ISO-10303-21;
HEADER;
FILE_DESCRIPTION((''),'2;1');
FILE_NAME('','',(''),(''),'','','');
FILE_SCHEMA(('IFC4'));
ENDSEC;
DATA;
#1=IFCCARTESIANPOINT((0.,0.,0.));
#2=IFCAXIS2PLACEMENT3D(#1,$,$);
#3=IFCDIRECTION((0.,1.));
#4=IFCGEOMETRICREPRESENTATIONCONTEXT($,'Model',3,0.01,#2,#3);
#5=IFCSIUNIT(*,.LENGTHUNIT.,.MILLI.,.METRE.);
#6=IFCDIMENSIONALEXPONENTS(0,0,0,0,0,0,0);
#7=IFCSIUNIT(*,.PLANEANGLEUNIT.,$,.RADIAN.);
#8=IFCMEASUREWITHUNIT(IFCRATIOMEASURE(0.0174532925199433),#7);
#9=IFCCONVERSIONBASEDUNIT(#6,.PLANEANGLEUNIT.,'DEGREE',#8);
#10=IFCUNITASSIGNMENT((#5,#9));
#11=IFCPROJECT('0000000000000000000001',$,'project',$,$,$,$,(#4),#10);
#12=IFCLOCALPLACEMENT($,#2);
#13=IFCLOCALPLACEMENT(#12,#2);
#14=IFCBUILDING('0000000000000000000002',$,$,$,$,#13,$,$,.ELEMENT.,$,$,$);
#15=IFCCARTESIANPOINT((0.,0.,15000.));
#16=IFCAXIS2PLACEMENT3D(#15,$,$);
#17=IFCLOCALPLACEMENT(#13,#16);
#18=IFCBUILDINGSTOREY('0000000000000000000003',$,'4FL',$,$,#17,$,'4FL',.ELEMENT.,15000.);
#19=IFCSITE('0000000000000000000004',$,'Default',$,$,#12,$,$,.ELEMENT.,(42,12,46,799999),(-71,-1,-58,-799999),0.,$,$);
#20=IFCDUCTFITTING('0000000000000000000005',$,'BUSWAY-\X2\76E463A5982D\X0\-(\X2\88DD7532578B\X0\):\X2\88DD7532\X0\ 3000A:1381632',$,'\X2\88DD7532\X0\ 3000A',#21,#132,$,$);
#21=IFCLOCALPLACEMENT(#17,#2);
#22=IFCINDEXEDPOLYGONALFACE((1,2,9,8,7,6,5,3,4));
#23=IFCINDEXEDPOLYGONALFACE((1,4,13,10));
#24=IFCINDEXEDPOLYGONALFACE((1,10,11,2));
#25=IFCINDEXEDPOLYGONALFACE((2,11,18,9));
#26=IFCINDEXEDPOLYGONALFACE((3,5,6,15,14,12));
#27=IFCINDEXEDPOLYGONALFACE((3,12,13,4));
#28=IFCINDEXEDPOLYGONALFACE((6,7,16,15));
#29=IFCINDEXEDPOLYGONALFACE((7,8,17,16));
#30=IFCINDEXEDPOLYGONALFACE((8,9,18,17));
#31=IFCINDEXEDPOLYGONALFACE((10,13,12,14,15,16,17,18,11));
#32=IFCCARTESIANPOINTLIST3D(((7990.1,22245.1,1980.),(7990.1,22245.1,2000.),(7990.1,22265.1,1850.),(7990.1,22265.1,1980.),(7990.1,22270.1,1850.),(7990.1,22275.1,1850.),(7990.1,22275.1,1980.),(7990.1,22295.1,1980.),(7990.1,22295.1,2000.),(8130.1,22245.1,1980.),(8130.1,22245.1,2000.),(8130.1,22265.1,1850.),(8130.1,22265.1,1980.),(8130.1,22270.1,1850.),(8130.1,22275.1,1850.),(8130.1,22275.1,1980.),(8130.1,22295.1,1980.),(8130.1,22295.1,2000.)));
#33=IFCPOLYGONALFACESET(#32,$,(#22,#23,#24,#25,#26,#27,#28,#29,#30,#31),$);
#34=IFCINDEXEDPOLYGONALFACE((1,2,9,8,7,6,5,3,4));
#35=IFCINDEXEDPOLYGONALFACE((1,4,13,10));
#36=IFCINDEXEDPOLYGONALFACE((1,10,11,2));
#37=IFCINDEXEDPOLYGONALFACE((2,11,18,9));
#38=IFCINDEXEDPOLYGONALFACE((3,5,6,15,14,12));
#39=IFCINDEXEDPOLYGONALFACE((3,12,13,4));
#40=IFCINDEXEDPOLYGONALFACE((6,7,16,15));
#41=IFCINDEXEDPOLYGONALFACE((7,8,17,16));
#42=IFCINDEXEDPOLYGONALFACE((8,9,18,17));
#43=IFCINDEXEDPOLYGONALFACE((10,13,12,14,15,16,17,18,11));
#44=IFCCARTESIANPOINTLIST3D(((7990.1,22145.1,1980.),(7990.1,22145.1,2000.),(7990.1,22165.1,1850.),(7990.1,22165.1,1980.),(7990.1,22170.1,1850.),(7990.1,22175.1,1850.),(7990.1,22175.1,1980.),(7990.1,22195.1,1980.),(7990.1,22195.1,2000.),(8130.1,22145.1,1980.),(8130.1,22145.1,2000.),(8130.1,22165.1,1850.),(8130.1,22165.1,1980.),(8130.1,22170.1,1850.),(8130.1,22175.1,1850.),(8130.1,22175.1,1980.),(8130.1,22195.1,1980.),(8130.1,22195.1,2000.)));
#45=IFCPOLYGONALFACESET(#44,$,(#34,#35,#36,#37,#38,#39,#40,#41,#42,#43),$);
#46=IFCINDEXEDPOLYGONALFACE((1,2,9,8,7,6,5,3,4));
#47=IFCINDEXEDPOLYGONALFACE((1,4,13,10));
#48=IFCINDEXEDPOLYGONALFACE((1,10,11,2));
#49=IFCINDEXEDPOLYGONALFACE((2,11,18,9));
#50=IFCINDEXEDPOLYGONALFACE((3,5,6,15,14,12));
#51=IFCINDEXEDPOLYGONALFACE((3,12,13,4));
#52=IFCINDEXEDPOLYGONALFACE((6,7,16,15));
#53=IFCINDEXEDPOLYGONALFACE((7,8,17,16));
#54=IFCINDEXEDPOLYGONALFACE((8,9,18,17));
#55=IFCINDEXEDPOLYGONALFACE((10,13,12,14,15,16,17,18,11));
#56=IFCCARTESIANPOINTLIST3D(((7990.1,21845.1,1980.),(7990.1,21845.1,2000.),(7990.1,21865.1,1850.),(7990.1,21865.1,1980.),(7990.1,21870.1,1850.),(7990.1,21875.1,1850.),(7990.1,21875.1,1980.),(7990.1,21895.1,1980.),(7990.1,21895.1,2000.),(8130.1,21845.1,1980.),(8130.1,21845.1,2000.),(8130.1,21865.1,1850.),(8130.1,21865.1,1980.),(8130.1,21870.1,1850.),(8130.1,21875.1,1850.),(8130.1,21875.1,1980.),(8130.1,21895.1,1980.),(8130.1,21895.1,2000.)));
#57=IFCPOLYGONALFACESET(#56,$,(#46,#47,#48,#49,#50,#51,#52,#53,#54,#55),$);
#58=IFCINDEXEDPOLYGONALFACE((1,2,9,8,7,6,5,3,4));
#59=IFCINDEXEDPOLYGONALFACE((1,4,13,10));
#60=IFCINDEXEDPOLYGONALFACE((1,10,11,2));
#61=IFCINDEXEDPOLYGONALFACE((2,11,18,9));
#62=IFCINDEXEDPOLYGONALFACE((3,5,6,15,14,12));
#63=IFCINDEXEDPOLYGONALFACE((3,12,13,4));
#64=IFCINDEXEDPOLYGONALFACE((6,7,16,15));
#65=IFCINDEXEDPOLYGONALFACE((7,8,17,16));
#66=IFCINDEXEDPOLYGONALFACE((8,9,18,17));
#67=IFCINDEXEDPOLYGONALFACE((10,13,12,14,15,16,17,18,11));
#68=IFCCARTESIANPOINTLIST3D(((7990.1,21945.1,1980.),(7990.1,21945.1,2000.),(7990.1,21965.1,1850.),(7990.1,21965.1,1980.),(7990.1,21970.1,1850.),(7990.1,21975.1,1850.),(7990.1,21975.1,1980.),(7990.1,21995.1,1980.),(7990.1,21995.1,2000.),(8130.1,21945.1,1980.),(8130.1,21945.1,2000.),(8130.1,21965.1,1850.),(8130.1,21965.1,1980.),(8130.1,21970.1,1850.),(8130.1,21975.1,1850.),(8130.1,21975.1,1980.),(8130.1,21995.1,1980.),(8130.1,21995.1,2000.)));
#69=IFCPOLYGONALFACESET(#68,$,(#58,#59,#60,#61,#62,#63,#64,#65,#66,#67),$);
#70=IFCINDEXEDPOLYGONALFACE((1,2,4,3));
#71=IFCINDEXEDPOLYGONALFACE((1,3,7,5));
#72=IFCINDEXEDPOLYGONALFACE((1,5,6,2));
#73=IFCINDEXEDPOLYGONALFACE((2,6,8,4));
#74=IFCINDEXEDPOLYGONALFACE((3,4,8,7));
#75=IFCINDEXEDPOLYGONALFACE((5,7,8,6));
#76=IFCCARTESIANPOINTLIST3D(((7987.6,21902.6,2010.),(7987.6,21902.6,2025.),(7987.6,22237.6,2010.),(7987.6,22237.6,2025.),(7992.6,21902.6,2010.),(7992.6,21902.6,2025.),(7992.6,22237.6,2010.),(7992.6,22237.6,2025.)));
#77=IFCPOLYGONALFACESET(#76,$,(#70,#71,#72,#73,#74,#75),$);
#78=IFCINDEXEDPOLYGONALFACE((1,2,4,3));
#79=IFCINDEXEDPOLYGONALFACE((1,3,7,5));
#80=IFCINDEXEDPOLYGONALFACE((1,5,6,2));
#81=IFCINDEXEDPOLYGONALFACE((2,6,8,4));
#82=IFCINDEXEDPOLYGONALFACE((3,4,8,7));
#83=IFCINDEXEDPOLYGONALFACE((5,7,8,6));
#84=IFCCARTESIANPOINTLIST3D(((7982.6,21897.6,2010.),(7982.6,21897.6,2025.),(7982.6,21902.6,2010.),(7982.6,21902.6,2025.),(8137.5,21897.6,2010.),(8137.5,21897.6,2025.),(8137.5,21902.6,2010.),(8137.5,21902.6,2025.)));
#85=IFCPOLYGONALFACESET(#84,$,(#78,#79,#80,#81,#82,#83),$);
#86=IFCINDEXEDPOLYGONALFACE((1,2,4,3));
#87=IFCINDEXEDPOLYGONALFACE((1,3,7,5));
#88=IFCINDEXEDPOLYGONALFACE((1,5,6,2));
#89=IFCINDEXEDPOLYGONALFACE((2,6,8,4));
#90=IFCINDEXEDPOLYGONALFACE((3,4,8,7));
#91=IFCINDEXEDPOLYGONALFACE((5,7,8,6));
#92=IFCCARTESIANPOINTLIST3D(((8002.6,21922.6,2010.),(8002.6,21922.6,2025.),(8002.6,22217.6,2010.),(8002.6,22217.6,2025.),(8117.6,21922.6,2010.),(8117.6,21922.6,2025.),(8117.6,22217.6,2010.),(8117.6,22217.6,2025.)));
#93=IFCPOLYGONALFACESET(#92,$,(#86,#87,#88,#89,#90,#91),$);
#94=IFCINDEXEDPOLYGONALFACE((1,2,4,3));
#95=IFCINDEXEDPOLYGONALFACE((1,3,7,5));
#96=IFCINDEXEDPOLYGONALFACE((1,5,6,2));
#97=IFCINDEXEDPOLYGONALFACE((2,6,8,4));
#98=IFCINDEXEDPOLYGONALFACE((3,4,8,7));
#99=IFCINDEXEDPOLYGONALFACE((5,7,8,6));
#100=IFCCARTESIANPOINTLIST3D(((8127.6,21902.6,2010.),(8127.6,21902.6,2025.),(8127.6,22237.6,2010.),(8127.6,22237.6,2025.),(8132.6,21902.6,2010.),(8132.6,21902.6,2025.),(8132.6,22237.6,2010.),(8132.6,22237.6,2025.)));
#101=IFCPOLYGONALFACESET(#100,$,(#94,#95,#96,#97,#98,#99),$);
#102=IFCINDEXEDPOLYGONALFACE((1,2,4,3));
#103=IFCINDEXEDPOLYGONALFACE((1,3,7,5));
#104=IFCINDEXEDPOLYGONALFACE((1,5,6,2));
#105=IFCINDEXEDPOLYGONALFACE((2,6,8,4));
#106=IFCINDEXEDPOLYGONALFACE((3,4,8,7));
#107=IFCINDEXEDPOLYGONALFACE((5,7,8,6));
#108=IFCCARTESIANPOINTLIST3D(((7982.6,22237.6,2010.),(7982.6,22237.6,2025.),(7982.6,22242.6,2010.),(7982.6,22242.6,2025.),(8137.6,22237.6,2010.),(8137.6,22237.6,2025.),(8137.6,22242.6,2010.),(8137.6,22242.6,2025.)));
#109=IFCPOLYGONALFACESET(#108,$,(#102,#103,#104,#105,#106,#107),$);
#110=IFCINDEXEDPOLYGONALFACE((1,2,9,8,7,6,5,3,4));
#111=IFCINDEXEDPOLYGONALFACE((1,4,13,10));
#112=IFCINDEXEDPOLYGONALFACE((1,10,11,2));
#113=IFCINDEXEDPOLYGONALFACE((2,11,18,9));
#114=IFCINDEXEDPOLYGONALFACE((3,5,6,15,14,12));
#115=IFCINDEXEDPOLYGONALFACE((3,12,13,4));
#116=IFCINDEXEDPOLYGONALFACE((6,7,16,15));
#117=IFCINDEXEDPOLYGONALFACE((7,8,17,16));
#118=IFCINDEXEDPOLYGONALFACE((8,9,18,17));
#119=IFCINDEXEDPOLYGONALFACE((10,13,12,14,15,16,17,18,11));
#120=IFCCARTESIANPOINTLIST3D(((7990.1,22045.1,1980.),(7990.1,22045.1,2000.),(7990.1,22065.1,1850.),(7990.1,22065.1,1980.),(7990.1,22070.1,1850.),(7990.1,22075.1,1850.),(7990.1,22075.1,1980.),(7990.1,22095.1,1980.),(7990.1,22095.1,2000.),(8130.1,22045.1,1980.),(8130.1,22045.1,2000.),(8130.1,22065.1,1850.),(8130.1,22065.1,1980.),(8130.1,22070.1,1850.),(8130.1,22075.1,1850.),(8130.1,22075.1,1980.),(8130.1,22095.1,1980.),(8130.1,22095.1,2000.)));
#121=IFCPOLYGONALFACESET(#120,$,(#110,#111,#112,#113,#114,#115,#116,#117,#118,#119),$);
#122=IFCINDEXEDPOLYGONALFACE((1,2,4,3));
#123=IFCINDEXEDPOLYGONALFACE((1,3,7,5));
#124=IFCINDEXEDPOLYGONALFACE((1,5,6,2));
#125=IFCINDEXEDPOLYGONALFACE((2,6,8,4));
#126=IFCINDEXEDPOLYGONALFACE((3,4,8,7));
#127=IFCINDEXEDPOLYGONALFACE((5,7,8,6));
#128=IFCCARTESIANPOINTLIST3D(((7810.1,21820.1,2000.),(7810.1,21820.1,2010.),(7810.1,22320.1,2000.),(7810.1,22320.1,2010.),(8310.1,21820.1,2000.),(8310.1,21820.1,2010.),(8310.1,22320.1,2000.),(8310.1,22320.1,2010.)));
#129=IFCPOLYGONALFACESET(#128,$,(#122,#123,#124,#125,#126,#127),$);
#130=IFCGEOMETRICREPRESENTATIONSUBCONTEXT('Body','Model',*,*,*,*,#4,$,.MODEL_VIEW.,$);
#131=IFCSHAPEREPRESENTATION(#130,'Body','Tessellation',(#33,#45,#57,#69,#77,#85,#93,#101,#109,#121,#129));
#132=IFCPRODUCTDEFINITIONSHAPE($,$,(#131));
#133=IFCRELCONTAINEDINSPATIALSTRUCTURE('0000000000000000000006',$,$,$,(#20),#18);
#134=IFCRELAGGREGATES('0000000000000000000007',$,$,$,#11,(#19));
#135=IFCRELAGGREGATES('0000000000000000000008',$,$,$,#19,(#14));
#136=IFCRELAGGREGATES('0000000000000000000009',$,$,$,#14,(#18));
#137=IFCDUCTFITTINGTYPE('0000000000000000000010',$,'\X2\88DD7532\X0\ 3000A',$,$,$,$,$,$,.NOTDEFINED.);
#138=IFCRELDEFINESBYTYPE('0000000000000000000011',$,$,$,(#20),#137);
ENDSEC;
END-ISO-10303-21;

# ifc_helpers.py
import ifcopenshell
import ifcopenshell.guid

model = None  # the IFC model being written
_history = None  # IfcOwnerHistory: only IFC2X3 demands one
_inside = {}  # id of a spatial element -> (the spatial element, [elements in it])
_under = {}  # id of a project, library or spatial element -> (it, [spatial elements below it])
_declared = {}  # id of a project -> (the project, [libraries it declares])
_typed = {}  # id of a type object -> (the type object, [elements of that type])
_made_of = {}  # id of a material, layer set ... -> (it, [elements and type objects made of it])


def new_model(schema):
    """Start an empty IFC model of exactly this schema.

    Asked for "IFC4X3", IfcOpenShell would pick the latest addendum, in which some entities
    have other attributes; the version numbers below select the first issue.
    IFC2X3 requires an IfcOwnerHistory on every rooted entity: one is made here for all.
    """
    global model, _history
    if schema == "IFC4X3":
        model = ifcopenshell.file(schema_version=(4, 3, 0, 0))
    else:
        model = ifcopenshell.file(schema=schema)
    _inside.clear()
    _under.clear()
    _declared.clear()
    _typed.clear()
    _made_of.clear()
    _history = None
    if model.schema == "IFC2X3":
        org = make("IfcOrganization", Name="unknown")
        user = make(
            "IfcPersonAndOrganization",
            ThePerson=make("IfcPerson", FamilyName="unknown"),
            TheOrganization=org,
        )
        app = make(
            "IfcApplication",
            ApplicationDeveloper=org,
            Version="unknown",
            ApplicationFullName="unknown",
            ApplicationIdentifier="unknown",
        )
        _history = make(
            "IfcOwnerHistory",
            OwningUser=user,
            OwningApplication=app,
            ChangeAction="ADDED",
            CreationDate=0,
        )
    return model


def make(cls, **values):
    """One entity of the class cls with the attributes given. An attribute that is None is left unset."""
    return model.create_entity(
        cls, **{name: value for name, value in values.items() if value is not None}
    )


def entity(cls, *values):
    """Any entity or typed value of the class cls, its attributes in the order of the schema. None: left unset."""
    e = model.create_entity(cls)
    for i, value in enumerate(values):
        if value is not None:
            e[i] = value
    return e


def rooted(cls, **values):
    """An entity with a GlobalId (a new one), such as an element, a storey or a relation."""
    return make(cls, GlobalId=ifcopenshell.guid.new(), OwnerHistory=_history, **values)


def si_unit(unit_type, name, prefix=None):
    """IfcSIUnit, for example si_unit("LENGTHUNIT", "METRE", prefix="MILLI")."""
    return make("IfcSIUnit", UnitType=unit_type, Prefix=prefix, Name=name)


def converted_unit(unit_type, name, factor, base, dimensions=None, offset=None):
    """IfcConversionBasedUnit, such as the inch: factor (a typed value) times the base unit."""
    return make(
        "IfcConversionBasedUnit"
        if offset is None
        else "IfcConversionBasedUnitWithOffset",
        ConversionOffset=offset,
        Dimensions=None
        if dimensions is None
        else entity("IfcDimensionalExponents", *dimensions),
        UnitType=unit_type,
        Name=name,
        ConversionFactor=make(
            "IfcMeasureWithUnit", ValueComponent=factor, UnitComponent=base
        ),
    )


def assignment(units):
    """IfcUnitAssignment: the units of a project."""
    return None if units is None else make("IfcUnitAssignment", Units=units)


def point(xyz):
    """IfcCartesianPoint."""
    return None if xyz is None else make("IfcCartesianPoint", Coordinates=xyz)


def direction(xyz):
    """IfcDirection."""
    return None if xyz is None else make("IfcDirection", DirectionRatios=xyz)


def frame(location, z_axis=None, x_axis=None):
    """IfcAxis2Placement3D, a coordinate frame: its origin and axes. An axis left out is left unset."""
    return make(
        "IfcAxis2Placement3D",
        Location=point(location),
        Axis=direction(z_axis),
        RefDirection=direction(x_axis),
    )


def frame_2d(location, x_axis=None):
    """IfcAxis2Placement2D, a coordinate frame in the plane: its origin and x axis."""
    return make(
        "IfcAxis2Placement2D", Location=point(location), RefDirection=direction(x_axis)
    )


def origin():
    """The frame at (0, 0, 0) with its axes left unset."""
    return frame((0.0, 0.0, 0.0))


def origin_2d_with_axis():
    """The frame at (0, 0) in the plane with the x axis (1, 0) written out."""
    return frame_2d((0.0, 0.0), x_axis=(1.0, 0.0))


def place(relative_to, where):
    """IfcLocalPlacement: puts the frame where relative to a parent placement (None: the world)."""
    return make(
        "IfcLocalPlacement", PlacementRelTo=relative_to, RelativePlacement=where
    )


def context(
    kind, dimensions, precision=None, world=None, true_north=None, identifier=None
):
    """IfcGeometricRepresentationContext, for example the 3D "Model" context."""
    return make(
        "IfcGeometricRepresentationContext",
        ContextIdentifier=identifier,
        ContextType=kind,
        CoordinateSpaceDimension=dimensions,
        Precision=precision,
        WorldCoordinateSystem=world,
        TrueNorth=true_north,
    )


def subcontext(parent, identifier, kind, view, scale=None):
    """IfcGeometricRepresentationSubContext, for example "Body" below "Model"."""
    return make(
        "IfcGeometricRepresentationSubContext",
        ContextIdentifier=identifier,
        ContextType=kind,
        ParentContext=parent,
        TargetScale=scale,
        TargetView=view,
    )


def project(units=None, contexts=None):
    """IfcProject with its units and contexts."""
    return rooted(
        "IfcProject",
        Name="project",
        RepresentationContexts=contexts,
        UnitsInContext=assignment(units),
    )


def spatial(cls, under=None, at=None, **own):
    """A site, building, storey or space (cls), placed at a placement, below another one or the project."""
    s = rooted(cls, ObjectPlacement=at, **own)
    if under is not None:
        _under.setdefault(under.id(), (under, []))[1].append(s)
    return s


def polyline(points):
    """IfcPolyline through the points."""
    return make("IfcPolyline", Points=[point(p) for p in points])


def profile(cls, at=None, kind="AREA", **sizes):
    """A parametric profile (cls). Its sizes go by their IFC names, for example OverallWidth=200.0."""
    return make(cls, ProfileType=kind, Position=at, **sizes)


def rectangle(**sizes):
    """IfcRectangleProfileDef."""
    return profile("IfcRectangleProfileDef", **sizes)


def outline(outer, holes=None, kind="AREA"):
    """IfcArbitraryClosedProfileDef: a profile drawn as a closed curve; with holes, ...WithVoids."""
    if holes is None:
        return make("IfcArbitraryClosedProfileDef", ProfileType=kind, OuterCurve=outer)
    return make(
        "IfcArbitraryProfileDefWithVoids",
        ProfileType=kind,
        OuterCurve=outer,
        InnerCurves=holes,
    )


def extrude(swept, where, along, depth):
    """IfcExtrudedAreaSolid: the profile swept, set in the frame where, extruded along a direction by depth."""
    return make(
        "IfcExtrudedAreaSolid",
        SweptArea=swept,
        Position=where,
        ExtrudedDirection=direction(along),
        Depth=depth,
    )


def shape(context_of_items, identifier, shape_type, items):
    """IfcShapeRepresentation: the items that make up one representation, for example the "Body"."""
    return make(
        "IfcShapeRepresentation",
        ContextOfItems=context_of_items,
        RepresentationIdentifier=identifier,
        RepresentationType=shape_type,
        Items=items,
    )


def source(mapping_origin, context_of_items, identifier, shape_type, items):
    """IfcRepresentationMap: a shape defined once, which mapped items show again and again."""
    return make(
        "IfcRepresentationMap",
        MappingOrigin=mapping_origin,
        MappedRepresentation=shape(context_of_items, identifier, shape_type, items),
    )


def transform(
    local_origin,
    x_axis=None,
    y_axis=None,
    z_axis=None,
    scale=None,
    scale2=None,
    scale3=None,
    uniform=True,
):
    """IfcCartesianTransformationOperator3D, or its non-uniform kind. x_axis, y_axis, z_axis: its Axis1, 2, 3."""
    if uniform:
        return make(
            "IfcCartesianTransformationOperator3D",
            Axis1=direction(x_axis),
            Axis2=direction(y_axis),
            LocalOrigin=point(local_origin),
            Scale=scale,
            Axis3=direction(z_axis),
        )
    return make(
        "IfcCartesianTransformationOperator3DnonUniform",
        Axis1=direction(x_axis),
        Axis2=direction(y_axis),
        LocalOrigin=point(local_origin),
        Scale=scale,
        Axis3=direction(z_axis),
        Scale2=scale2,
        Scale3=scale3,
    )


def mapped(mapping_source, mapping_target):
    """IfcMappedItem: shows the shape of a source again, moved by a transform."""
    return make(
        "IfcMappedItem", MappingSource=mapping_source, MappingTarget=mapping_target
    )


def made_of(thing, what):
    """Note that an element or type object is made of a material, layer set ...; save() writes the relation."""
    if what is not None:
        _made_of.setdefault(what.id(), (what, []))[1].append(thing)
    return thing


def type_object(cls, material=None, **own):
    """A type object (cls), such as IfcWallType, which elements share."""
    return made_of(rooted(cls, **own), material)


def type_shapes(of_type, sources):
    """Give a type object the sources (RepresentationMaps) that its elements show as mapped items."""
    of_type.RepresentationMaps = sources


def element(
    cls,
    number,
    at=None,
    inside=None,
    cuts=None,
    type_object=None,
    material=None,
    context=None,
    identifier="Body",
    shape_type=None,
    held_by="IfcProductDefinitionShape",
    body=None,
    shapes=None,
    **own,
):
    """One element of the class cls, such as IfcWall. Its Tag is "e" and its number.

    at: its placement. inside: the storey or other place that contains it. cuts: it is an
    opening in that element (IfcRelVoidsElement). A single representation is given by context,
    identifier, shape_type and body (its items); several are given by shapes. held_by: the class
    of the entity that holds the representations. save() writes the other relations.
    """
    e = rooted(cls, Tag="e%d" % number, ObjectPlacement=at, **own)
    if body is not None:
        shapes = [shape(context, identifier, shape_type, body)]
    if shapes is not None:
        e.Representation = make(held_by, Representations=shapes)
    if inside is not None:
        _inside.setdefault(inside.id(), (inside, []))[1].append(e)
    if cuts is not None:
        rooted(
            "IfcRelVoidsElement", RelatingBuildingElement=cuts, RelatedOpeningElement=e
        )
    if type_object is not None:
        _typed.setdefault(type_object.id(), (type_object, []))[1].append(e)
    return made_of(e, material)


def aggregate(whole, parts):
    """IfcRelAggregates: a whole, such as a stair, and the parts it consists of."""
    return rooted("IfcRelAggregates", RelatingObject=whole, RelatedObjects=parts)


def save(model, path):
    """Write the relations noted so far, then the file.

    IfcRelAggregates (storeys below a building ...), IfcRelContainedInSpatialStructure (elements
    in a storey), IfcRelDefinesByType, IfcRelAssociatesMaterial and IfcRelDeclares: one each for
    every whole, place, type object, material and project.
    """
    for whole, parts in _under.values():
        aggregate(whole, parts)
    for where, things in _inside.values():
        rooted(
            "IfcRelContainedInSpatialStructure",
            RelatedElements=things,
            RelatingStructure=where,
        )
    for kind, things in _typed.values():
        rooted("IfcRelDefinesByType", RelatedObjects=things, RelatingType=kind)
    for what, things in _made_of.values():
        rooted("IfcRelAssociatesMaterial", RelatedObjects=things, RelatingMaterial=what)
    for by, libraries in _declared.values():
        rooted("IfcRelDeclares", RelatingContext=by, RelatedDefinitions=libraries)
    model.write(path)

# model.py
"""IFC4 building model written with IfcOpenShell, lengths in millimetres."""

from ifc_helpers import new_model, entity, si_unit, converted_unit, direction, frame, frame_2d, origin, origin_2d_with_axis, place, context, subcontext, project, spatial, polyline, rectangle, outline, extrude, source, transform, mapped, type_object, type_shapes, element, save


model = new_model("IFC4")

# Units and contexts
model_context = context("Model", 3, precision=0.01, world=origin(), true_north=direction((0.0, 1.0)))
body_context = subcontext(model_context, "Body", "Model", "MODEL_VIEW")
ifc_project = project(units=[si_unit("LENGTHUNIT", "METRE", prefix="MILLI"), converted_unit("PLANEANGLEUNIT", "DEGREE", entity("IfcRatioMeasure", 0.0174532925199433), si_unit("PLANEANGLEUNIT", "RADIAN"), dimensions=[0, 0, 0, 0, 0, 0, 0])], contexts=[model_context])

# Site, building, storey
site_placement = place(None, origin())
site = spatial("IfcSite", under=ifc_project, at=site_placement, Name="Default", CompositionType="ELEMENT", RefLatitude=(42, 12, 46, 799999), RefLongitude=(-71, -1, -58, -799999), RefElevation=0.0)
building_placement = place(site_placement, origin())
building = spatial("IfcBuilding", under=site, at=building_placement, CompositionType="ELEMENT")
storey_placement = place(building_placement, frame((0.0, 0.0, 15000.0)))
storey = spatial("IfcBuildingStorey", under=building, at=storey_placement, Name="4FL", LongName="4FL", CompositionType="ELEMENT", Elevation=15000.0)

# Duct fitting
duct_fitting_type_1 = type_object("IfcDuctFittingType", Name="裝甲 3000A", PredefinedType="NOTDEFINED")
shared_shape_1 = source(origin(), body_context, "Body", "SweptSolid", [
    extrude(outline(polyline([(-25.0, -58.9), (25.0, -58.9), (25.0, -38.9), (5.0, -38.9), (5.0, 91.1), (0.0, 91.1), (-5.0, 91.1), (-5.0, -38.9), (-25.0, -38.9), (-25.0, -58.9)])), frame((-200.0, -70.0, -58.9), z_axis=(0.0, 1.0, 0.0), x_axis=(1.0, 0.0, 0.0)), (0.0, 0.0, 1.0), 140.0),
    extrude(outline(polyline([(-25.0, -58.9), (25.0, -58.9), (25.0, -38.9), (5.0, -38.9), (5.0, 91.1), (0.0, 91.1), (-5.0, 91.1), (-5.0, -38.9), (-25.0, -38.9), (-25.0, -58.9)])), frame((-100.0, -70.0, -58.9), z_axis=(0.0, 1.0, 0.0), x_axis=(1.0, 0.0, 0.0)), (0.0, 0.0, 1.0), 140.0),
    extrude(outline(polyline([(-58.9, -25.0), (-38.9, -25.0), (-38.9, -5.0), (91.1, -5.0), (91.1, 0.0), (91.1, 5.0), (-38.9, 5.0), (-38.9, 25.0), (-58.9, 25.0), (-58.9, -25.0)])), frame((200.0, -70.0, -58.9), z_axis=(0.0, 1.0, 0.0), x_axis=(0.0, 0.0, -1.0)), (0.0, 0.0, 1.0), 140.0),
    extrude(outline(polyline([(-58.9, -25.0), (-38.9, -25.0), (-38.9, -5.0), (91.1, -5.0), (91.1, 0.0), (91.1, 5.0), (-38.9, 5.0), (-38.9, 25.0), (-58.9, 25.0), (-58.9, -25.0)])), frame((100.0, -70.0, -58.9), z_axis=(0.0, 1.0, 0.0), x_axis=(0.0, 0.0, -1.0)), (0.0, 0.0, 1.0), 140.0),
    extrude(rectangle(XDim=335.0, YDim=5.0, at=origin_2d_with_axis()), frame((0.0, -70.0, 10.0), z_axis=(0.0, 0.0, 1.0), x_axis=(-1.0, 0.0, 0.0)), (0.0, 0.0, 1.0), 15.0),
    extrude(rectangle(XDim=5.0, YDim=154.9, at=frame_2d((0.0, 0.0), x_axis=(1.0, 0.0))), frame((170.0, -0.1, 10.0), z_axis=(0.0, 0.0, 1.0), x_axis=(-1.0, 0.0, 0.0)), (0.0, 0.0, 1.0), 15.0),
    extrude(rectangle(XDim=295.0, YDim=115.0, at=origin_2d_with_axis()), frame((0.0, 0.0, 10.0), z_axis=(0.0, 0.0, 1.0), x_axis=(-1.0, 0.0, 0.0)), (0.0, 0.0, 1.0), 15.0),
    extrude(rectangle(XDim=335.0, YDim=5.0, at=origin_2d_with_axis()), frame((0.0, 70.0, 10.0), z_axis=(0.0, 0.0, 1.0), x_axis=(-1.0, 0.0, 0.0)), (0.0, 0.0, 1.0), 15.0),
    extrude(rectangle(XDim=5.0, YDim=155.0, at=origin_2d_with_axis()), frame((-170.0, 0.0, 10.0), z_axis=(0.0, 0.0, 1.0), x_axis=(-1.0, 0.0, 0.0)), (0.0, 0.0, 1.0), 15.0),
    extrude(outline(polyline([(-58.9, -25.0), (-38.9, -25.0), (-38.9, -5.0), (91.1, -5.0), (91.1, 0.0), (91.1, 5.0), (-38.9, 5.0), (-38.9, 25.0), (-58.9, 25.0), (-58.9, -25.0)])), frame((0.0, -70.0, -58.9), z_axis=(0.0, 1.0, 0.0), x_axis=(0.0, 0.0, -1.0)), (0.0, 0.0, 1.0), 140.0),
    extrude(rectangle(XDim=500.0, YDim=500.0, at=origin_2d_with_axis()), frame((0.0, 0.0, 0.0), z_axis=(0.0, 0.0, 1.0), x_axis=(0.0, 1.0, 0.0)), (0.0, 0.0, 1.0), 10.0),
])
type_shapes(duct_fitting_type_1, [shared_shape_1])
duct_fitting_1_placement = place(storey_placement, frame((8060.1, 22070.1, 2000.0), z_axis=(0.0, 0.0, 1.0), x_axis=(0.0, -1.0, 0.0)))
element("IfcDuctFitting", 1, at=duct_fitting_1_placement, inside=storey, type_object=duct_fitting_type_1, Name="BUSWAY-盤接頭-(裝甲型):裝甲 3000A:1381632", ObjectType="裝甲 3000A", context=body_context, shape_type="MappedRepresentation", body=[
    mapped(shared_shape_1, transform((0.0, 0.0, 0.0), scale=1.0)),
])

save(model, "model.ifc")
